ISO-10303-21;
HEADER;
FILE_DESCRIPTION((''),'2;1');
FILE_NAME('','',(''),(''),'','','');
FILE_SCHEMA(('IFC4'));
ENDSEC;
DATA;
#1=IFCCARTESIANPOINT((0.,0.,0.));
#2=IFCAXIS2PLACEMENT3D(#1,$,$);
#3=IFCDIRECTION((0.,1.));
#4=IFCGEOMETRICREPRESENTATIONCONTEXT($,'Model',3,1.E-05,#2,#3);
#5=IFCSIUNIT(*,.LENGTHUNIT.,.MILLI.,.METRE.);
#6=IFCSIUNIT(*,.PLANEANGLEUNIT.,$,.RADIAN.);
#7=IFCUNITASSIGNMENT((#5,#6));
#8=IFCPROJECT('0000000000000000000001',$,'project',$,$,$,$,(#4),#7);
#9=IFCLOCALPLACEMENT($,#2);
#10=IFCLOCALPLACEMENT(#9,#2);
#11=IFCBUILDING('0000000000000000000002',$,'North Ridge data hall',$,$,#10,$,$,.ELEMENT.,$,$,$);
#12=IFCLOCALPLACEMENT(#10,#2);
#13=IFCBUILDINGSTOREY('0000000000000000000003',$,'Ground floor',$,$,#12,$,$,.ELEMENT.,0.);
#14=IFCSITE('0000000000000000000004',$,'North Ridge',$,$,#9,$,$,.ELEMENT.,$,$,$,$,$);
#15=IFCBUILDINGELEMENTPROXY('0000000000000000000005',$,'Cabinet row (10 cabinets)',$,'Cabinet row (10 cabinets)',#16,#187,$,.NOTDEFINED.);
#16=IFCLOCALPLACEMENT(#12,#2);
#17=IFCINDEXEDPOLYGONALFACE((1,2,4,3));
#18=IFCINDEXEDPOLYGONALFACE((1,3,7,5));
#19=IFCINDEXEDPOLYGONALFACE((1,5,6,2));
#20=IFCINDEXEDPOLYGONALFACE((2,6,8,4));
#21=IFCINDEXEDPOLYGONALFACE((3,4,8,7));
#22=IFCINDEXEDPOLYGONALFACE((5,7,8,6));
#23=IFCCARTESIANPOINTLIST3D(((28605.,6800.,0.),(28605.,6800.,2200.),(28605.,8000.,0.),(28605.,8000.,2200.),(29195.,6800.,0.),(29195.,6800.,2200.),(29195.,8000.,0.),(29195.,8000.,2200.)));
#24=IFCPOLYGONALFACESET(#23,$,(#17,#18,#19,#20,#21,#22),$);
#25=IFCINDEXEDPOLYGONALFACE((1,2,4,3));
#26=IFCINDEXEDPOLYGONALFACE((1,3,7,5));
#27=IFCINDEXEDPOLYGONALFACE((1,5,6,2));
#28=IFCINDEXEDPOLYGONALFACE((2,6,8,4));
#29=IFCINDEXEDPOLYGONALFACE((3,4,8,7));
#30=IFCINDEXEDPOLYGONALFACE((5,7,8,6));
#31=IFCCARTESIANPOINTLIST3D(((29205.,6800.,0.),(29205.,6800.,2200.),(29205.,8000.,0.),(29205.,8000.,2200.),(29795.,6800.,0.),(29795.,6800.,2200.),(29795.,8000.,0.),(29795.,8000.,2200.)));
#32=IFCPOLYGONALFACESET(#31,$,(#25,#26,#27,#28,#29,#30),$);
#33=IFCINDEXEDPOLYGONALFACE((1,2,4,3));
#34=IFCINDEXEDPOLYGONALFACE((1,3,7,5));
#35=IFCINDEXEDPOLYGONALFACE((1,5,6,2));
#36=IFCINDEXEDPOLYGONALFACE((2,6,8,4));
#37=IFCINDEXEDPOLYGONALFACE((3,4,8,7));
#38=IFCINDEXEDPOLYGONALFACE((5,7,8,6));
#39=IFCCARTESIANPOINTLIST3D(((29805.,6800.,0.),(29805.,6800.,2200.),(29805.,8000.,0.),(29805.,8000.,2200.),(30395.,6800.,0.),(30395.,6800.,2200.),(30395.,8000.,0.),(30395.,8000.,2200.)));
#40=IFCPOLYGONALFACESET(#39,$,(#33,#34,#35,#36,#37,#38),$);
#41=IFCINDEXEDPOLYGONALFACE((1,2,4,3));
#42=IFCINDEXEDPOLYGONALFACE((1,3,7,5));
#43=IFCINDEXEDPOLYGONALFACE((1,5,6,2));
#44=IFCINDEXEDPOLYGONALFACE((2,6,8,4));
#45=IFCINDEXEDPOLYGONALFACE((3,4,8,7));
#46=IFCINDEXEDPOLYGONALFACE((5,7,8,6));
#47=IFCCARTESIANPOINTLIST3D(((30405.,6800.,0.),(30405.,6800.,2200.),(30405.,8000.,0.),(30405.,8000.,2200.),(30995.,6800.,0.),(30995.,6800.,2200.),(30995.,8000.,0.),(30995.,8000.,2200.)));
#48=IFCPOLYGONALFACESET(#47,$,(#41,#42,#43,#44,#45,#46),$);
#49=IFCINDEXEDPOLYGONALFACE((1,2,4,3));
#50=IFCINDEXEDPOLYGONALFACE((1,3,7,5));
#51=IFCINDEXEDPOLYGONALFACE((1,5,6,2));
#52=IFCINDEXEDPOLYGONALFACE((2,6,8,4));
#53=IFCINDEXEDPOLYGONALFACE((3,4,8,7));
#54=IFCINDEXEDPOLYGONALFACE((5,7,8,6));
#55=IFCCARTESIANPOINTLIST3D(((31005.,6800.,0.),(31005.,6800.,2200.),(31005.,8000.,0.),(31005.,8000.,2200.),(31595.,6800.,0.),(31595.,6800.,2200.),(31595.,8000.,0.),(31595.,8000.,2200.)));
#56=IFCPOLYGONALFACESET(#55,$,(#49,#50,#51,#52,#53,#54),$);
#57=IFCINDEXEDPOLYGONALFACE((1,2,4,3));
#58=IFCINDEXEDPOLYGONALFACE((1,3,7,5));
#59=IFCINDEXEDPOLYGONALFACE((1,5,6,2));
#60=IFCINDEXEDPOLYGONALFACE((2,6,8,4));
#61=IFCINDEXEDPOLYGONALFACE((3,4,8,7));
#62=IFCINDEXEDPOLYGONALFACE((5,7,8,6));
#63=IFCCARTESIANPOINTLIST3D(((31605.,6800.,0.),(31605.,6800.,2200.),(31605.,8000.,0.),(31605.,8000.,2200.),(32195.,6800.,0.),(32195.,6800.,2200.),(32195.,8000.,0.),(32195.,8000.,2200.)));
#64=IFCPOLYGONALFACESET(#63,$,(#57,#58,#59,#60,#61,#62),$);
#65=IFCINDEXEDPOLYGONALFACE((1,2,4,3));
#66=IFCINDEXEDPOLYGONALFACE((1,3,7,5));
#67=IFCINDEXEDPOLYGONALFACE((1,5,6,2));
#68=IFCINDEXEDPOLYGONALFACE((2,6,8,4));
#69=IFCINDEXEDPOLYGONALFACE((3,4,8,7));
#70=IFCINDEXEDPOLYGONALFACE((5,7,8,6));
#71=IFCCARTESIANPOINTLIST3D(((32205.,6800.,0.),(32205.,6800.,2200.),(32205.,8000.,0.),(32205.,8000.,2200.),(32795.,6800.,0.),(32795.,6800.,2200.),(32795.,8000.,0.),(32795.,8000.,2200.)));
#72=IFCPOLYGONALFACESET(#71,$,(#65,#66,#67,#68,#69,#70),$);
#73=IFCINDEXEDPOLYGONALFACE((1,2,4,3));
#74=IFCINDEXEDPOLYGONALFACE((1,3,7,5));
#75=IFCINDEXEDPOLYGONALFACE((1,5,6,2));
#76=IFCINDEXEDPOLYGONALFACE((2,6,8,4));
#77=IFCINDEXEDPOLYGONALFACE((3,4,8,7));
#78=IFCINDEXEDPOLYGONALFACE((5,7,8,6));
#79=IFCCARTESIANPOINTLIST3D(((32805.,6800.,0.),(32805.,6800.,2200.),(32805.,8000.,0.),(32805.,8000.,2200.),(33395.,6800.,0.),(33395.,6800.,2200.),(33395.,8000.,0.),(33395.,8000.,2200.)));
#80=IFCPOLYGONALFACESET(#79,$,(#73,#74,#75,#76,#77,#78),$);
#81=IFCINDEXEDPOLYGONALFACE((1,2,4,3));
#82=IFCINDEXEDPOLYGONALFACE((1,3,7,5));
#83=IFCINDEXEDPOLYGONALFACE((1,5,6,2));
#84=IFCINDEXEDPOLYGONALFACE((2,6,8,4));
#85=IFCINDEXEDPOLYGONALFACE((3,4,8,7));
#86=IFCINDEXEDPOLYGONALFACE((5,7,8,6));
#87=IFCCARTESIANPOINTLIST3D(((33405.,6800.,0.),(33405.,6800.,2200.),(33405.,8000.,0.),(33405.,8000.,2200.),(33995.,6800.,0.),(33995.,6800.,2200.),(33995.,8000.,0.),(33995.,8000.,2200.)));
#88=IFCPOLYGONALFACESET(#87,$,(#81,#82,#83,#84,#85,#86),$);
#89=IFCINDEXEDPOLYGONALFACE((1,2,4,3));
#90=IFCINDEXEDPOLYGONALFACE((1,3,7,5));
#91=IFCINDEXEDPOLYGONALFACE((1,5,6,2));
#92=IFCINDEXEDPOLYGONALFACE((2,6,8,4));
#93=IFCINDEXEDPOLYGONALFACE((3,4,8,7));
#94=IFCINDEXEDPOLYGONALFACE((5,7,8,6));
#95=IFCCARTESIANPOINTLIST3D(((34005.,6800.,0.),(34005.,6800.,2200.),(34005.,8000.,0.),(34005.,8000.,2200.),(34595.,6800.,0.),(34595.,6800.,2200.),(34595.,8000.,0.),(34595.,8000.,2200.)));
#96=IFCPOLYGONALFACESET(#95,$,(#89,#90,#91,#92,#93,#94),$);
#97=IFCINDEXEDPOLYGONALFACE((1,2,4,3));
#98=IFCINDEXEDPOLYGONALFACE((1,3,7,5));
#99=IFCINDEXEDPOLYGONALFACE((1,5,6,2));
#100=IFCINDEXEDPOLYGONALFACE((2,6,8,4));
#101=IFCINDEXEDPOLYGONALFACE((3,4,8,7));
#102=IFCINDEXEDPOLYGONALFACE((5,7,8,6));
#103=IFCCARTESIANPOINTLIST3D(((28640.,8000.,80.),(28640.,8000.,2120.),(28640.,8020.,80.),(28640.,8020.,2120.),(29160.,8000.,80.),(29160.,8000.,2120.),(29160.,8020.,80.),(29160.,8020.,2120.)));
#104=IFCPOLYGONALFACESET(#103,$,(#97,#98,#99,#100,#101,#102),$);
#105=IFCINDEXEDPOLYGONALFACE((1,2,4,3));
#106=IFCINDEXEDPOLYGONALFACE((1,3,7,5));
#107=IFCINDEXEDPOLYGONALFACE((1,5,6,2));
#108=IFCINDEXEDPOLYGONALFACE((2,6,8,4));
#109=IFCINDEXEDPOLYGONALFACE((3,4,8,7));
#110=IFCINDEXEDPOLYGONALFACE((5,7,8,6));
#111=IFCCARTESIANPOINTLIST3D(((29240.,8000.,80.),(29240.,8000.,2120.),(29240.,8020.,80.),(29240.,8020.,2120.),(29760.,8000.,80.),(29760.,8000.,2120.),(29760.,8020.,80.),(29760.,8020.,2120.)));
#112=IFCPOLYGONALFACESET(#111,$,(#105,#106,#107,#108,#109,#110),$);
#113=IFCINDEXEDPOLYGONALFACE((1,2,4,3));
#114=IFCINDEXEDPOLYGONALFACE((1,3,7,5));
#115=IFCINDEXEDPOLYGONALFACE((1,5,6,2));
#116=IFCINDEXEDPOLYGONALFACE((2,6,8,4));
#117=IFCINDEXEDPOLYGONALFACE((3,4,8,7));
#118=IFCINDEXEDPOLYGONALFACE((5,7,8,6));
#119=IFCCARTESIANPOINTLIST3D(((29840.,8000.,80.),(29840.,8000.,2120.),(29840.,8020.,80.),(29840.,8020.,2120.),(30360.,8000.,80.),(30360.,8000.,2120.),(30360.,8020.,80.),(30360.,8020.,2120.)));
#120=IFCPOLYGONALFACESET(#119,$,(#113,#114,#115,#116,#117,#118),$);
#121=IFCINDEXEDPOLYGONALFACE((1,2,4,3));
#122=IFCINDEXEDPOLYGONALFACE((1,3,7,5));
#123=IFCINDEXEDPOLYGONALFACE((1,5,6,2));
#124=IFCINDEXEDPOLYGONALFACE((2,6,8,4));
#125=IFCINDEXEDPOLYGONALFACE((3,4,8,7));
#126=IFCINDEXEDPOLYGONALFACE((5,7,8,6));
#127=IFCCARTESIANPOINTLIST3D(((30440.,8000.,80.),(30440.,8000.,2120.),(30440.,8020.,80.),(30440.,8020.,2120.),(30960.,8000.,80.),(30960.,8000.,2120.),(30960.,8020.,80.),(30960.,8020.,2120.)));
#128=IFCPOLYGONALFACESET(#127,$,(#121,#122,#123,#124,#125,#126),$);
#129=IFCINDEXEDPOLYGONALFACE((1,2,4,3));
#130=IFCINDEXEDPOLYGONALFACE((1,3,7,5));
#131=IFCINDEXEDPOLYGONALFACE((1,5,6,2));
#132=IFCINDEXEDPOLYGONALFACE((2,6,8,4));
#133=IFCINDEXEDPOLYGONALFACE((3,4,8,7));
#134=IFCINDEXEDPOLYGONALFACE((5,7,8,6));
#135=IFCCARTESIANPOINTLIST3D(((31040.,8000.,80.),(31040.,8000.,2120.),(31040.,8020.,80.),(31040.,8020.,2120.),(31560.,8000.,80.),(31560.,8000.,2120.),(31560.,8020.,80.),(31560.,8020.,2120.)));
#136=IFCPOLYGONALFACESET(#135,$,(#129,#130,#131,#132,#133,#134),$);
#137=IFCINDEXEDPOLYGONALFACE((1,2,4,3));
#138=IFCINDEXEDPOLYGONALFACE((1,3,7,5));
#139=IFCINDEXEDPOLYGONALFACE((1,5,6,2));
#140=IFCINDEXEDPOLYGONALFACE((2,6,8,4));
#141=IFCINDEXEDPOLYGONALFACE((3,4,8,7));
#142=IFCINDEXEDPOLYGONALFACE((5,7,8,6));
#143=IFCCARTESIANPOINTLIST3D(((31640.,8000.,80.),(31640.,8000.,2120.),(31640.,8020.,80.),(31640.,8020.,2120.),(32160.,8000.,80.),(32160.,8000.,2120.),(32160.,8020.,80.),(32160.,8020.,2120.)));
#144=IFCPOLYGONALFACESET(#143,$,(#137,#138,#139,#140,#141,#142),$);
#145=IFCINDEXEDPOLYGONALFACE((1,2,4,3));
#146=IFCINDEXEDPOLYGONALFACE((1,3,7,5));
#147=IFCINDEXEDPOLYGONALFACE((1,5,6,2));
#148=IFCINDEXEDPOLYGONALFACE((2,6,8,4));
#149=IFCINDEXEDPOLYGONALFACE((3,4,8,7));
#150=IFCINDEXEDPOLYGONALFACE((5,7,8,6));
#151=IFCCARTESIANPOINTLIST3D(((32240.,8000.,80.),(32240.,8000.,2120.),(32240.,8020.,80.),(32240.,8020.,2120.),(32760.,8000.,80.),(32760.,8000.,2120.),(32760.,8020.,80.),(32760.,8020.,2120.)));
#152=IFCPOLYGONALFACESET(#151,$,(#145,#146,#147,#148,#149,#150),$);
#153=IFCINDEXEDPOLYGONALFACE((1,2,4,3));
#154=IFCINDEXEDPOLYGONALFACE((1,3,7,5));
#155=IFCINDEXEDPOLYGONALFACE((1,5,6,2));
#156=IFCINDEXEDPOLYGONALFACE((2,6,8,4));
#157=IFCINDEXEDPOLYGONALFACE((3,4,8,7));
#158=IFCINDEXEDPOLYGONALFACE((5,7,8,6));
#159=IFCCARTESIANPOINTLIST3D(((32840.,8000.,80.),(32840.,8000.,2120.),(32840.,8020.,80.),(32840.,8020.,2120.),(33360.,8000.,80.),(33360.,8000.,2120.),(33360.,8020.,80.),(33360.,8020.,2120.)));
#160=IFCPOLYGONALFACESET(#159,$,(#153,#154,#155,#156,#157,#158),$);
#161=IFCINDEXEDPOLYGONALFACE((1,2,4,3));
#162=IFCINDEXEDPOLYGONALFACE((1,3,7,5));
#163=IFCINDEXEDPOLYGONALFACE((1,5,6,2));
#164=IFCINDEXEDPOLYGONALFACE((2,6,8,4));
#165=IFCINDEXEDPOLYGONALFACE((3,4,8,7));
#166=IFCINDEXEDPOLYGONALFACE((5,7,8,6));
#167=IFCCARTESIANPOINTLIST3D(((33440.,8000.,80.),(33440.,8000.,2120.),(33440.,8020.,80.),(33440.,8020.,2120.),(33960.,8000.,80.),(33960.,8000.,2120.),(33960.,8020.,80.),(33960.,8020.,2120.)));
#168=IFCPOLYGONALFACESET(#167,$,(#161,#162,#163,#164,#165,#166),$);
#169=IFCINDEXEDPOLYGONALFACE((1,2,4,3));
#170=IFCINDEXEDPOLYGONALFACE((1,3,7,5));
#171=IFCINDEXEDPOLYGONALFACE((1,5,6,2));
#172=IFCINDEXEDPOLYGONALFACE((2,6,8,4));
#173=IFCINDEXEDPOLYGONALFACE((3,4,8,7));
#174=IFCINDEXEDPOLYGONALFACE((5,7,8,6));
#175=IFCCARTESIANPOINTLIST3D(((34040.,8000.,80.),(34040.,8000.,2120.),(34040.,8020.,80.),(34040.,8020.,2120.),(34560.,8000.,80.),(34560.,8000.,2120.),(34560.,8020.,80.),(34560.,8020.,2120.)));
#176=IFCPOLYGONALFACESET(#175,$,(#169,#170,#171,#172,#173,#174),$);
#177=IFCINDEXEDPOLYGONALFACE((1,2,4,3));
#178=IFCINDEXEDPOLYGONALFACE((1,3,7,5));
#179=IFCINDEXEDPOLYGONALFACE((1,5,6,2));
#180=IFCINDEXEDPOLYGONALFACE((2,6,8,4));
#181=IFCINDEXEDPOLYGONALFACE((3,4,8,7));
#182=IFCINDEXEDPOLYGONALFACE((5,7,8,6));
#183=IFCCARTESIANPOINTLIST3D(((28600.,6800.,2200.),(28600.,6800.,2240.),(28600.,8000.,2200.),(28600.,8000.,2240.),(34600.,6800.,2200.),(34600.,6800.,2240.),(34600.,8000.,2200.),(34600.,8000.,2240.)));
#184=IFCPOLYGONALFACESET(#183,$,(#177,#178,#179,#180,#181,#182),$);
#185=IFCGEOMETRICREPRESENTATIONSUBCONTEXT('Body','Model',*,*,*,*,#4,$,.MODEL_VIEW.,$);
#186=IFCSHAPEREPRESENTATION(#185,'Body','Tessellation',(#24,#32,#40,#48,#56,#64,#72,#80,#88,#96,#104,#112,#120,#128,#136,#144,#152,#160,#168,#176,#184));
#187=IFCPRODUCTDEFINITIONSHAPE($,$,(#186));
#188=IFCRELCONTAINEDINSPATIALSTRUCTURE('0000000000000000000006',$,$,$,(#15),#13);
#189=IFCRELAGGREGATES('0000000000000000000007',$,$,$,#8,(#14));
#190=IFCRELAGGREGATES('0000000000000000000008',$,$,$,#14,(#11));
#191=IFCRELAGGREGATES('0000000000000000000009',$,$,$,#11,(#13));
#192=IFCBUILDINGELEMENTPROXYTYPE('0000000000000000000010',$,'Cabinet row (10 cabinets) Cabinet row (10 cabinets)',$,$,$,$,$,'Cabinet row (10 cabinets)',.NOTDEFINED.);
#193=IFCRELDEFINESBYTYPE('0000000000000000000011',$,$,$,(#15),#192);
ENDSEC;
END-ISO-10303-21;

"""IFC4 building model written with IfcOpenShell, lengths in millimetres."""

from ifc_helpers import new_model, si_unit, direction, frame, origin, place, context, subcontext, project, spatial, polyline, outline, extrude, source, transform, mapped, type_object, type_shapes, element, save


model = new_model("IFC4")

# Units and contexts
model_context = context("Model", 3, precision=1e-05, world=origin(), true_north=direction((0.0, 1.0)))
body_context = subcontext(model_context, "Body", "Model", "MODEL_VIEW")
ifc_project = project(units=[si_unit("LENGTHUNIT", "METRE", prefix="MILLI"), si_unit("PLANEANGLEUNIT", "RADIAN")], contexts=[model_context])

# Site, building, storey
site_placement = place(None, origin())
site = spatial("IfcSite", under=ifc_project, at=site_placement, Name="North Ridge", CompositionType="ELEMENT")
building_placement = place(site_placement, origin())
building = spatial("IfcBuilding", under=site, at=building_placement, Name="North Ridge data hall", CompositionType="ELEMENT")
storey_placement = place(building_placement, origin())
storey = spatial("IfcBuildingStorey", under=building, at=storey_placement, Name="Ground floor", CompositionType="ELEMENT", Elevation=0.0)

# Building element proxy
building_element_proxy_type_1 = type_object("IfcBuildingElementProxyType", Name="Cabinet row (10 cabinets) Cabinet row (10 cabinets)", ElementType="Cabinet row (10 cabinets)", PredefinedType="NOTDEFINED")
shared_shape_1 = source(origin(), body_context, "Body", "SweptSolid", [
    extrude(outline(polyline([(5.0, 0.0), (595.0, 0.0), (595.0, 1200.0), (5.0, 1200.0), (5.0, 0.0)])), origin(), (0.0, 0.0, 1.0), 2200.0),
    extrude(outline(polyline([(605.0, 0.0), (1195.0, 0.0), (1195.0, 1200.0), (605.0, 1200.0), (605.0, 0.0)])), origin(), (0.0, 0.0, 1.0), 2200.0),
    extrude(outline(polyline([(1205.0, 0.0), (1795.0, 0.0), (1795.0, 1200.0), (1205.0, 1200.0), (1205.0, 0.0)])), origin(), (0.0, 0.0, 1.0), 2200.0),
    extrude(outline(polyline([(1805.0, 0.0), (2395.0, 0.0), (2395.0, 1200.0), (1805.0, 1200.0), (1805.0, 0.0)])), origin(), (0.0, 0.0, 1.0), 2200.0),
    extrude(outline(polyline([(2405.0, 0.0), (2995.0, 0.0), (2995.0, 1200.0), (2405.0, 1200.0), (2405.0, 0.0)])), origin(), (0.0, 0.0, 1.0), 2200.0),
    extrude(outline(polyline([(3005.0, 0.0), (3595.0, 0.0), (3595.0, 1200.0), (3005.0, 1200.0), (3005.0, 0.0)])), origin(), (0.0, 0.0, 1.0), 2200.0),
    extrude(outline(polyline([(3605.0, 0.0), (4195.0, 0.0), (4195.0, 1200.0), (3605.0, 1200.0), (3605.0, 0.0)])), origin(), (0.0, 0.0, 1.0), 2200.0),
    extrude(outline(polyline([(4205.0, 0.0), (4795.0, 0.0), (4795.0, 1200.0), (4205.0, 1200.0), (4205.0, 0.0)])), origin(), (0.0, 0.0, 1.0), 2200.0),
    extrude(outline(polyline([(4805.0, 0.0), (5395.0, 0.0), (5395.0, 1200.0), (4805.0, 1200.0), (4805.0, 0.0)])), origin(), (0.0, 0.0, 1.0), 2200.0),
    extrude(outline(polyline([(5405.0, 0.0), (5995.0, 0.0), (5995.0, 1200.0), (5405.0, 1200.0), (5405.0, 0.0)])), origin(), (0.0, 0.0, 1.0), 2200.0),
    extrude(outline(polyline([(40.0, 1200.0), (560.0, 1200.0), (560.0, 1220.0), (40.0, 1220.0), (40.0, 1200.0)])), frame((0.0, 0.0, 80.0)), (0.0, 0.0, 1.0), 2040.0),
    extrude(outline(polyline([(640.0, 1200.0), (1160.0, 1200.0), (1160.0, 1220.0), (640.0, 1220.0), (640.0, 1200.0)])), frame((0.0, 0.0, 80.0)), (0.0, 0.0, 1.0), 2040.0),
    extrude(outline(polyline([(1240.0, 1200.0), (1760.0, 1200.0), (1760.0, 1220.0), (1240.0, 1220.0), (1240.0, 1200.0)])), frame((0.0, 0.0, 80.0)), (0.0, 0.0, 1.0), 2040.0),
    extrude(outline(polyline([(1840.0, 1200.0), (2360.0, 1200.0), (2360.0, 1220.0), (1840.0, 1220.0), (1840.0, 1200.0)])), frame((0.0, 0.0, 80.0)), (0.0, 0.0, 1.0), 2040.0),
    extrude(outline(polyline([(2440.0, 1200.0), (2960.0, 1200.0), (2960.0, 1220.0), (2440.0, 1220.0), (2440.0, 1200.0)])), frame((0.0, 0.0, 80.0)), (0.0, 0.0, 1.0), 2040.0),
    extrude(outline(polyline([(3040.0, 1200.0), (3560.0, 1200.0), (3560.0, 1220.0), (3040.0, 1220.0), (3040.0, 1200.0)])), frame((0.0, 0.0, 80.0)), (0.0, 0.0, 1.0), 2040.0),
    extrude(outline(polyline([(3640.0, 1200.0), (4160.0, 1200.0), (4160.0, 1220.0), (3640.0, 1220.0), (3640.0, 1200.0)])), frame((0.0, 0.0, 80.0)), (0.0, 0.0, 1.0), 2040.0),
    extrude(outline(polyline([(4240.0, 1200.0), (4760.0, 1200.0), (4760.0, 1220.0), (4240.0, 1220.0), (4240.0, 1200.0)])), frame((0.0, 0.0, 80.0)), (0.0, 0.0, 1.0), 2040.0),
    extrude(outline(polyline([(4840.0, 1200.0), (5360.0, 1200.0), (5360.0, 1220.0), (4840.0, 1220.0), (4840.0, 1200.0)])), frame((0.0, 0.0, 80.0)), (0.0, 0.0, 1.0), 2040.0),
    extrude(outline(polyline([(5440.0, 1200.0), (5960.0, 1200.0), (5960.0, 1220.0), (5440.0, 1220.0), (5440.0, 1200.0)])), frame((0.0, 0.0, 80.0)), (0.0, 0.0, 1.0), 2040.0),
    extrude(outline(polyline([(0.0, 0.0), (6000.0, 0.0), (6000.0, 1200.0), (0.0, 1200.0), (0.0, 0.0)])), frame((0.0, 0.0, 2200.0)), (0.0, 0.0, 1.0), 40.0),
])
type_shapes(building_element_proxy_type_1, [shared_shape_1])
for number, where, z_axis, x_axis, name in (
    (1, (28600.0, 6800.0, 0.0), (0.0, 0.0, 1.0), (1.0, 0.0, 0.0), "Cabinet row (10 cabinets)"),
):
    element("IfcBuildingElementProxy", number, at=place(storey_placement, frame(where, z_axis=z_axis, x_axis=x_axis)), inside=storey, type_object=building_element_proxy_type_1, Name=name, ObjectType="Cabinet row (10 cabinets)", PredefinedType="NOTDEFINED", context=body_context, shape_type="MappedRepresentation", body=[
        mapped(shared_shape_1, transform((0.0, 0.0, 0.0))),
    ])

save(model, "model.ifc")
